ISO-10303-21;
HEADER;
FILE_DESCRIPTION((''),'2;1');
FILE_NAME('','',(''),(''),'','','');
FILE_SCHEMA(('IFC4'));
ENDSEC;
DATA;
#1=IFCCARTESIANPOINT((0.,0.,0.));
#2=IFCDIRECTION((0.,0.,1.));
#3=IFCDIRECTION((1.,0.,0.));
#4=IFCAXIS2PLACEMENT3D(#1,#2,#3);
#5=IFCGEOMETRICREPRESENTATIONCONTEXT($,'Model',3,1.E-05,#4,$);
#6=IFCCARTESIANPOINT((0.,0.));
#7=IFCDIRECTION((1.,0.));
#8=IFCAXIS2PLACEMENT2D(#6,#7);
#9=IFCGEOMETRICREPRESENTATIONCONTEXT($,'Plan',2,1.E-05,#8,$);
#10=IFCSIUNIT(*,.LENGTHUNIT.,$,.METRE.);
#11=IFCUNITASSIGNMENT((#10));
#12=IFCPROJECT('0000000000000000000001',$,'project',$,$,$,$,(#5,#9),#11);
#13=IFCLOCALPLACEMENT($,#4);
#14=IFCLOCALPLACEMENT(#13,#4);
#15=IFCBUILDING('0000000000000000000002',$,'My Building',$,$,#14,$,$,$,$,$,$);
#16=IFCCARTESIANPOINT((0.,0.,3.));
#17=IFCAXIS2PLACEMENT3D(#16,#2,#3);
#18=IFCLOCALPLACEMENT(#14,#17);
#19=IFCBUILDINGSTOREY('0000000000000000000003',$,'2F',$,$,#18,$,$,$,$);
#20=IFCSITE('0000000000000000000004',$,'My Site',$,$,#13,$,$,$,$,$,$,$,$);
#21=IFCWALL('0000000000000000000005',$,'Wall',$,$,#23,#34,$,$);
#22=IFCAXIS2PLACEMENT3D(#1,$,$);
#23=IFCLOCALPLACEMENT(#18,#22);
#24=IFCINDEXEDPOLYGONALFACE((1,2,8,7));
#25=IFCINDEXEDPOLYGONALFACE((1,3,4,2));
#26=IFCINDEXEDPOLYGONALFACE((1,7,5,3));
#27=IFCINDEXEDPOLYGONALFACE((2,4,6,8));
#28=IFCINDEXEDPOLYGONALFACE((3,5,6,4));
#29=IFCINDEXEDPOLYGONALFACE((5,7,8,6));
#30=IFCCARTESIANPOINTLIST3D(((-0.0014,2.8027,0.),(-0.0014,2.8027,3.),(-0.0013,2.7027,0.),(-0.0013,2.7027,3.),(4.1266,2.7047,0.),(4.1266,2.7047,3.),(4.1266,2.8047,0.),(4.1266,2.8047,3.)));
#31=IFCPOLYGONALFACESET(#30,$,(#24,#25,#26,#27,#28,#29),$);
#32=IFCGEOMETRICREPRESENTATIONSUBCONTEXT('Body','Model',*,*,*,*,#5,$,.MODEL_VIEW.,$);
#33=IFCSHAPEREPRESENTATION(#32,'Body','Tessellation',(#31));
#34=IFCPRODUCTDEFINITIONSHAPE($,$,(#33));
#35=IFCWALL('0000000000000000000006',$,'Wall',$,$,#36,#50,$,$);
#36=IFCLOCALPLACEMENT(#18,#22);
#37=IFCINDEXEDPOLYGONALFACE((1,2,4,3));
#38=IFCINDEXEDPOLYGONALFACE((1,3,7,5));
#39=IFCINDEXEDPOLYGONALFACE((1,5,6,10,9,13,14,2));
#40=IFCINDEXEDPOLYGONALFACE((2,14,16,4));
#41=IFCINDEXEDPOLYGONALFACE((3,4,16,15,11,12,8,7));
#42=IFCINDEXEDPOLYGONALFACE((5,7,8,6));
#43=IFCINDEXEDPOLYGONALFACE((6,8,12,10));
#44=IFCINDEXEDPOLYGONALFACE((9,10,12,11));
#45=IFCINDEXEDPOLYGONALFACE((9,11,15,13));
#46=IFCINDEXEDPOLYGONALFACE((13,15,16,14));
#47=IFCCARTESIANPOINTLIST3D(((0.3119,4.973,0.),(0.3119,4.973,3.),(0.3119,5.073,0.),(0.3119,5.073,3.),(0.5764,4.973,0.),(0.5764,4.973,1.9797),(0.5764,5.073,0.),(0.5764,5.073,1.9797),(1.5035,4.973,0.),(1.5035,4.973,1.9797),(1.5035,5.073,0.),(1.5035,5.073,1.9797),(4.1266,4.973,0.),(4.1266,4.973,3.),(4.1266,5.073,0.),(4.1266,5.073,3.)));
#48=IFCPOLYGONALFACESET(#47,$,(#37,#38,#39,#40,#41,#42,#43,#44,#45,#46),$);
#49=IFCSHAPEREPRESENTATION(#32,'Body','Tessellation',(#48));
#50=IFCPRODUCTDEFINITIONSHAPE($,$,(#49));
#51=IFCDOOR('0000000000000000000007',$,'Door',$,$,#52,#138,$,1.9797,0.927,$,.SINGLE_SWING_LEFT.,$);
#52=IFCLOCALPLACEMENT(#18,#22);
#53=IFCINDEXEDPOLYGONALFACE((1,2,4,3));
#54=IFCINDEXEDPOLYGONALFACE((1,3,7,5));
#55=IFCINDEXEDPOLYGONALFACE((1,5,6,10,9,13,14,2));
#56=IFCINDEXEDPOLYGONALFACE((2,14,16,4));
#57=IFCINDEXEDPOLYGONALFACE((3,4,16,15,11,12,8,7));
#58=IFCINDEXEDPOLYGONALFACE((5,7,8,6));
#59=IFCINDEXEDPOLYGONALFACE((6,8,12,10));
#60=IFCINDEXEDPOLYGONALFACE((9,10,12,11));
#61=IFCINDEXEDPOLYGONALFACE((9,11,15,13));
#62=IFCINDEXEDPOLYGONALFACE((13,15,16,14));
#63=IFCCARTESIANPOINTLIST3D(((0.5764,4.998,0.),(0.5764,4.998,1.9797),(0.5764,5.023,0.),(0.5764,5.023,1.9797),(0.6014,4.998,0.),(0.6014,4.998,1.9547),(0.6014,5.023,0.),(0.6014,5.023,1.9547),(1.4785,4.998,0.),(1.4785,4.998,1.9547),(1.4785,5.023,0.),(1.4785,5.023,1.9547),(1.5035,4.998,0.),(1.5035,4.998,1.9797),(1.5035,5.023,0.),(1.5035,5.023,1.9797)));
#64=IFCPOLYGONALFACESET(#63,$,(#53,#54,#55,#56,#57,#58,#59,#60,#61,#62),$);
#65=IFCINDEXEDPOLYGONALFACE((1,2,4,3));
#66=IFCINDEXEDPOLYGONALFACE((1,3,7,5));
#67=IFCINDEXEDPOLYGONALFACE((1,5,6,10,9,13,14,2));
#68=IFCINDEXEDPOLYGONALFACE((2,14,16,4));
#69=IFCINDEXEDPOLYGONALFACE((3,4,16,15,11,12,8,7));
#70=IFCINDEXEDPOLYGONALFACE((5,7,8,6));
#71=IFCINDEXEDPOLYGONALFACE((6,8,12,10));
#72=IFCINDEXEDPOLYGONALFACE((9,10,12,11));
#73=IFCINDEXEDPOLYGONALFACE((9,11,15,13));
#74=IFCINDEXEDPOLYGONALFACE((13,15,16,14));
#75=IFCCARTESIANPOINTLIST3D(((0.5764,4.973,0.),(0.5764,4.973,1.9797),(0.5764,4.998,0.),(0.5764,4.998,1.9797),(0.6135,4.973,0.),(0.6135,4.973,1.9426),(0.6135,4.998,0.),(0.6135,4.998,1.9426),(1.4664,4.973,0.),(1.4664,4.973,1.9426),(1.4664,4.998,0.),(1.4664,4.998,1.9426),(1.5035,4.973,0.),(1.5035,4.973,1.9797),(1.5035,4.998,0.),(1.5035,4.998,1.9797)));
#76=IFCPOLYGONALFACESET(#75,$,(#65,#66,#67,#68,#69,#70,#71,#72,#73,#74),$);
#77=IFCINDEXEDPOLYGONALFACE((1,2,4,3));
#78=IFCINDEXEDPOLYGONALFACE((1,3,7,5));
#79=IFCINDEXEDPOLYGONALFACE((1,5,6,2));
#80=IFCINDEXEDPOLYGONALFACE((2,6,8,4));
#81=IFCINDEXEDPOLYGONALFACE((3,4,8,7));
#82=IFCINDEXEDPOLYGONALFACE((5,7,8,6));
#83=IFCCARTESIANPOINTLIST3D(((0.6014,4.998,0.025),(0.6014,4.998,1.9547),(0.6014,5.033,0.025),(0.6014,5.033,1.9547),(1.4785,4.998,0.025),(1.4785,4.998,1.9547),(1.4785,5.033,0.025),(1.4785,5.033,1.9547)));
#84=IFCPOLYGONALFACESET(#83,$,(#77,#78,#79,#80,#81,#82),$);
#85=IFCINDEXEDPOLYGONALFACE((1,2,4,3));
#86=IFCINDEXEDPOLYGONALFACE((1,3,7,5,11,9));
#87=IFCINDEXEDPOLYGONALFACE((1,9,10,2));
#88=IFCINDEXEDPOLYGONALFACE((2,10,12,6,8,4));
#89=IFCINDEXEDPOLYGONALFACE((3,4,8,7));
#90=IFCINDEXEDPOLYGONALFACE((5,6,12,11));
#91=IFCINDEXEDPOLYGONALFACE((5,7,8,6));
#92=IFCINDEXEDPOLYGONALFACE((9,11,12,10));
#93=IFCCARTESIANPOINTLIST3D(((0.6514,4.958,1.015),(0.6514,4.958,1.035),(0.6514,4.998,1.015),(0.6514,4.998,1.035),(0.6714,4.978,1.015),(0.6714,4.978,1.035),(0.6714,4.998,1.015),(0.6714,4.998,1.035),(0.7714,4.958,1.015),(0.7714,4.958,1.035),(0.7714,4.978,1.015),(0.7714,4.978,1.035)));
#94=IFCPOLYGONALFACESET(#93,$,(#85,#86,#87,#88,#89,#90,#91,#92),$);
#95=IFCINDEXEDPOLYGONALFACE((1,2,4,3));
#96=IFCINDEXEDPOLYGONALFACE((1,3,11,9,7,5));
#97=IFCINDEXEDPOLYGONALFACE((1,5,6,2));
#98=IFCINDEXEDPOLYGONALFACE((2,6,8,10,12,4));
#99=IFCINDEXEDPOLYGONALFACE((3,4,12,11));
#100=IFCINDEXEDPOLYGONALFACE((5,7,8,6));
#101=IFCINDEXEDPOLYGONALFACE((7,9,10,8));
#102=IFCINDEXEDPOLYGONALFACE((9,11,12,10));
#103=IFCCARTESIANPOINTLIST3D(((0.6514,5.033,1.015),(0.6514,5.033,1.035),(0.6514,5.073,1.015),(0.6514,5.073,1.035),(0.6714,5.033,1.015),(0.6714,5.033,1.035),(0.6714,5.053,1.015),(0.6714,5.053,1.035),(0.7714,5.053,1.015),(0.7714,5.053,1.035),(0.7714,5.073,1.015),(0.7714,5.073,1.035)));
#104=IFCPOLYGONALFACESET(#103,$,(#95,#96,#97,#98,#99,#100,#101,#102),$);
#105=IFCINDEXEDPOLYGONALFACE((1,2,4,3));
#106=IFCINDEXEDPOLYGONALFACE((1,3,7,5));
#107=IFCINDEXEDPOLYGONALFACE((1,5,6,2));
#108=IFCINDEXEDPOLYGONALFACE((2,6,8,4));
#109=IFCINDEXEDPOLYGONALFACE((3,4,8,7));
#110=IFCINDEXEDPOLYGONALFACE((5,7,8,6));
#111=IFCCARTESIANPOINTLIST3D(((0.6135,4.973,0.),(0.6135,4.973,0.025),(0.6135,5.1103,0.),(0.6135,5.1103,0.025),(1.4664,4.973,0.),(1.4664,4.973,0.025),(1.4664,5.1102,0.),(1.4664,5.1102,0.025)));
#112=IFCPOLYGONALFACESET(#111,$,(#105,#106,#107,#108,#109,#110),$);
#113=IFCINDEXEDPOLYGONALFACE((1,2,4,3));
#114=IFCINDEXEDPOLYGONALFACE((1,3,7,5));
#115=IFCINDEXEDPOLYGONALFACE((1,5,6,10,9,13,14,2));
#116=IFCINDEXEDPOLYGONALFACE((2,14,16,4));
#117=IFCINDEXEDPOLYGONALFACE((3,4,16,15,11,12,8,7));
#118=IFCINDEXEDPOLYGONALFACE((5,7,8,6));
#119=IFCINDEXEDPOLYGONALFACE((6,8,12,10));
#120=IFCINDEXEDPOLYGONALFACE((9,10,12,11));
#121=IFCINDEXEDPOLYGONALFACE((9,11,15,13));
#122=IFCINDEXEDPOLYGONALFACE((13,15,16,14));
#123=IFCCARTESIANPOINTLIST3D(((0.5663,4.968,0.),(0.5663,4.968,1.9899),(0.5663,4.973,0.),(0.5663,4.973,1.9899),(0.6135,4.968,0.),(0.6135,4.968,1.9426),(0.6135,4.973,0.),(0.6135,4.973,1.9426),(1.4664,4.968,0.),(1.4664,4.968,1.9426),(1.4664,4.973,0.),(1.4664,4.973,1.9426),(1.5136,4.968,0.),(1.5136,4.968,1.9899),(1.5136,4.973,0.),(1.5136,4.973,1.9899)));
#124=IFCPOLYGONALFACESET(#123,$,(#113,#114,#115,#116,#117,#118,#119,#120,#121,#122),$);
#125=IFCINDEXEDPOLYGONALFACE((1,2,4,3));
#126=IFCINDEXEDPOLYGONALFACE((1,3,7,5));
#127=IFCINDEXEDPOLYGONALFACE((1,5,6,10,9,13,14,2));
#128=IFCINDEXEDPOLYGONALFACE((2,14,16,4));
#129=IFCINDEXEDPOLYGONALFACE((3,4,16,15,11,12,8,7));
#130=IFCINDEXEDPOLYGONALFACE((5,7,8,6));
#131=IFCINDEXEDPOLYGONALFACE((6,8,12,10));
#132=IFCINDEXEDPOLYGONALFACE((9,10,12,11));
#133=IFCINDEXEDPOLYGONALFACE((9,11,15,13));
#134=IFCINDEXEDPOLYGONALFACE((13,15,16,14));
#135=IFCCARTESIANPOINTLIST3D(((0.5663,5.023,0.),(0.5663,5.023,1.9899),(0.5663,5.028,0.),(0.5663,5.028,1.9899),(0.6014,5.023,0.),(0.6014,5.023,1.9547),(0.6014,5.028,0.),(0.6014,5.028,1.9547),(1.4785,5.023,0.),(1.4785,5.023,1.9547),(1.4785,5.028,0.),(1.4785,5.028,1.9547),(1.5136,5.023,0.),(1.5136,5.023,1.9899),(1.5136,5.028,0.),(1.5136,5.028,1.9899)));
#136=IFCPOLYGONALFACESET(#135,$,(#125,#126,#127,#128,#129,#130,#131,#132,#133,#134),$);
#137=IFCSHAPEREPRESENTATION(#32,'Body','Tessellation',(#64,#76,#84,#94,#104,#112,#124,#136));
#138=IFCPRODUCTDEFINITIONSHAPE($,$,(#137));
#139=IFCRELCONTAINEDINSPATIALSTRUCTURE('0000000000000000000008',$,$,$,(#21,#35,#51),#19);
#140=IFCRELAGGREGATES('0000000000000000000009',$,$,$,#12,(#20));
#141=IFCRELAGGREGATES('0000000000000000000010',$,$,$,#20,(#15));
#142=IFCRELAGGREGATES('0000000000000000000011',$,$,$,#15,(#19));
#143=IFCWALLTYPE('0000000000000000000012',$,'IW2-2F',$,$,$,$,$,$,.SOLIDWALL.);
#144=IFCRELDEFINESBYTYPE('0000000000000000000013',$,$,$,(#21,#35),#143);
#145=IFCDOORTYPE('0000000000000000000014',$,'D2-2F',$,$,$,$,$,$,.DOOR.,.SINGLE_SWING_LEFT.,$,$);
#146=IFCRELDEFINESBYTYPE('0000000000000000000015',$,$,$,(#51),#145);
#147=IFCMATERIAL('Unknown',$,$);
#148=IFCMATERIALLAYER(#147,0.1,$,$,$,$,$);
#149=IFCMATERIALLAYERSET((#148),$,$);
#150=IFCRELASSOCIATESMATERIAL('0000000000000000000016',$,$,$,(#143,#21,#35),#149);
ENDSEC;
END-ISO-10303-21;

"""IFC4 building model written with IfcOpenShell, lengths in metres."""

from ifc_helpers import new_model, entity, si_unit, frame, origin_with_axes, origin_2d_with_axis, place, context, subcontext, project, spatial, line, indexed_curve, outline, extrude, shape, source, transform, mapped, material, layer, layer_set, layer_usage, type_object, type_shapes, element, fill, save


model = new_model("IFC4")

# Units and contexts
model_context = context("Model", 3, precision=1e-05, world=origin_with_axes())
plan_context = context("Plan", 2, precision=1e-05, world=origin_2d_with_axis())
body_context_1 = subcontext(model_context, "Body", "Model", "MODEL_VIEW")
body_context_2 = subcontext(plan_context, "Body", "Plan", "PLAN_VIEW")
ifc_project = project(units=[si_unit("LENGTHUNIT", "METRE")], contexts=[model_context, plan_context])

# Site, building, storey
site_placement = place(None, origin_with_axes())
site = spatial("IfcSite", under=ifc_project, at=site_placement, Name="My Site")
building_placement = place(site_placement, origin_with_axes())
building = spatial("IfcBuilding", under=site, at=building_placement, Name="My Building")
storey_placement = place(building_placement, frame((0.0, 0.0, 3.0), z_axis=(0.0, 0.0, 1.0), x_axis=(1.0, 0.0, 0.0)))
storey = spatial("IfcBuildingStorey", under=building, at=storey_placement, Name="2F")

# Shared definitions
ifc_material = material(Name="Unknown")

# Wall
ifc_layer_1 = layer(ifc_material, 0.1)
ifc_layer_set_1 = layer_set([ifc_layer_1])
ifc_layer_usage_1 = layer_usage(ifc_layer_set_1, "AXIS2", "POSITIVE", 0.0)
wall_type_1 = type_object("IfcWallType", Name="IW2-2F", PredefinedType="SOLIDWALL", material=ifc_layer_set_1)
wall_1_placement = place(storey_placement, frame((-0.0013, 2.7027, 0.0), z_axis=(0.0, 0.0, 1.0), x_axis=(1.0, 0.000495, 0.0)))
element("IfcWall", 1, at=wall_1_placement, inside=storey, type_object=wall_type_1, material=ifc_layer_usage_1, Name="Wall", context=body_context_1, shape_type="SweptSolid", body=[
    extrude(outline(indexed_curve([(0.0, 0.0), (0.0, 0.1), (4.1279, 0.1), (4.1279, 0.0)], segments=[line(1, 2, 3, 4, 1)])), origin_with_axes(), (0.0, 0.0, 1.0), 3.0),
])

# Wall, opening, door
ifc_layer_usage_2 = layer_usage(ifc_layer_set_1, "AXIS2", "POSITIVE", 0.0)
wall_2_placement = place(storey_placement, frame((0.3119, 4.973, 0.0), z_axis=(0.0, 0.0, 1.0), x_axis=(1.0, -0.00002, 0.0)))
wall_2 = element("IfcWall", 2, at=wall_2_placement, inside=storey, type_object=wall_type_1, material=ifc_layer_usage_2, Name="Wall", context=body_context_1, shape_type="SweptSolid", body=[
    extrude(outline(indexed_curve([(0.0, 0.0), (0.0, 0.1), (3.8147, 0.1), (3.8147, 0.0)], segments=[line(1, 2, 3, 4, 1)])), origin_with_axes(), (0.0, 0.0, 1.0), 3.0),
])
shared_shape_1 = source(origin_with_axes(), body_context_1, "Body", "SweptSolid", [
    extrude(outline(indexed_curve([(0.0, 0.0), (0.927, 0.0), (0.927, 1.9797), (0.0, 1.9797)], segments=[line(1, 2, 3, 4, 1)])), frame((0.0, -0.6, 0.0), z_axis=(0.0, -1.0, 0.0), x_axis=(1.0, 0.0, 0.0)), (0.0, 0.0, -1.0), 1.2),
])
opening_1_placement = place(wall_2_placement, frame((0.2645, 0.0, 0.0), z_axis=(0.0, 0.0, 1.0), x_axis=(1.0, 0.0, 0.0)))
opening_1 = element("IfcOpeningElement", 3, at=opening_1_placement, cuts=wall_2, PredefinedType="OPENING", context=body_context_1, shape_type="MappedRepresentation", body=[
    mapped(shared_shape_1, transform((0.0, 0.0, 0.0), x_axis=(1.0, 0.0, 0.0), y_axis=(0.0, 1.0, 0.0), z_axis=(0.0, 0.0, 1.0), scale=1.0)),
])
door_type = type_object("IfcDoorType", Name="D2-2F", OperationType="SINGLE_SWING_LEFT", PredefinedType="DOOR")
shared_shape_2 = source(origin_with_axes(), body_context_1, "Body", "SweptSolid", [
    extrude(outline(indexed_curve([(0.0, 0.0), (0.0, 1.9797), (0.927, 1.9797), (0.927, 0.0), (0.902, 0.0), (0.902, 1.9547), (0.025, 1.9547), (0.025, 0.0)], segments=[line(1, 2, 3, 4, 5, 6, 7, 8, 1)])), frame((0.0, 0.025, 0.0), z_axis=(0.0, -1.0, 0.0), x_axis=(1.0, 0.0, 0.0)), (0.0, 0.0, -1.0), 0.025),
    extrude(outline(indexed_curve([(0.0, 0.0), (0.0, 1.9797), (0.927, 1.9797), (0.927, 0.0), (0.8899, 0.0), (0.8899, 1.9426), (0.0371, 1.9426), (0.0371, 0.0)], segments=[line(1, 2, 3, 4, 5, 6, 7, 8, 1)])), frame((0.0, 0.0, 0.0), z_axis=(0.0, -1.0, 0.0), x_axis=(1.0, 0.0, 0.0)), (0.0, 0.0, -1.0), 0.025),
    extrude(outline(indexed_curve([(0.0, 0.0), (0.877, 0.0), (0.877, 0.035), (0.0, 0.035)], segments=[line(1, 2, 3, 4, 1)])), frame((0.025, 0.025, 0.025), z_axis=(0.0, 0.0, 1.0), x_axis=(1.0, 0.0, 0.0)), (0.0, 0.0, 1.0), 1.9297),
    extrude(outline(indexed_curve([(0.0, 0.0), (0.0, -0.04), (0.12, -0.04), (0.12, -0.02), (0.02, -0.02), (0.02, 0.0)], segments=[line(1, 2, 3, 4, 5, 6, 1)])), frame((0.075, 0.025, 1.015), z_axis=(0.0, 0.0, 1.0), x_axis=(1.0, 0.0, 0.0)), (0.0, 0.0, 1.0), 0.02),
    extrude(outline(indexed_curve([(0.0, 0.0), (0.0, 0.04), (0.12, 0.04), (0.12, 0.02), (0.02, 0.02), (0.02, 0.0)], segments=[line(1, 2, 3, 4, 5, 6, 1)])), frame((0.075, 0.06, 1.015), z_axis=(0.0, 0.0, 1.0), x_axis=(1.0, 0.0, 0.0)), (0.0, 0.0, 1.0), 0.02),
    extrude(outline(indexed_curve([(0.0, 0.0), (0.8529, 0.0), (0.8529, 0.1372), (0.0, 0.1372)], segments=[line(1, 2, 3, 4, 1)])), frame((0.0371, 0.0, 0.0), z_axis=(0.0, 0.0, 1.0), x_axis=(1.0, 0.0, 0.0)), (0.0, 0.0, 1.0), 0.025),
    extrude(outline(indexed_curve([(0.0, 0.0), (0.0, 1.9899), (0.9474, 1.9899), (0.9474, 0.0), (0.9001, 0.0), (0.9001, 1.9426), (0.0473, 1.9426), (0.0473, 0.0)], segments=[line(1, 2, 3, 4, 5, 6, 7, 8, 1)])), frame((-0.0102, -0.005, 0.0), z_axis=(0.0, -1.0, 0.0), x_axis=(1.0, 0.0, 0.0)), (0.0, 0.0, -1.0), 0.005),
    extrude(outline(indexed_curve([(0.0, 0.0), (0.0, 1.9899), (0.9474, 1.9899), (0.9474, 0.0), (0.9122, 0.0), (0.9122, 1.9547), (0.0352, 1.9547), (0.0352, 0.0)], segments=[line(1, 2, 3, 4, 5, 6, 7, 8, 1)])), frame((-0.0102, 0.05, 0.0), z_axis=(0.0, -1.0, 0.0), x_axis=(1.0, 0.0, 0.0)), (0.0, 0.0, -1.0), 0.005),
])
shared_shape_3 = source(origin_with_axes(), body_context_2, "Body", "Curve2D", [
    entity("IfcIndexedPolyCurve", entity("IfcCartesianPointList2D", [[0.0, 0.0], [0.0, 0.05], [0.025, 0.05], [0.025, 0.025], [0.0371, 0.025], [0.0371, 0.0]]), [entity("IfcLineIndex", [1, 2, 3, 4, 5, 6, 1])]),
    entity("IfcIndexedPolyCurve", entity("IfcCartesianPointList2D", [[0.927, 0.0], [0.927, 0.05], [0.902, 0.05], [0.902, 0.025], [0.8899, 0.025], [0.8899, 0.0]]), [entity("IfcLineIndex", [1, 2, 3, 4, 5, 6, 1])]),
    entity("IfcTrimmedCurve", entity("IfcEllipse", entity("IfcAxis2Placement2D", entity("IfcCartesianPoint", [0.867, 0.05]), entity("IfcDirection", [1.0, 0.0])), 0.842, 0.877), [entity("IfcCartesianPoint", [0.867, 0.927])], [entity("IfcCartesianPoint", [0.025, 0.05])], True, "CARTESIAN"),
    entity("IfcIndexedPolyCurve", entity("IfcCartesianPointList2D", [[0.902, 0.05], [0.867, 0.05], [0.867, 0.927], [0.902, 0.927]]), [entity("IfcLineIndex", [1, 2, 3, 4, 1])]),
])
type_shapes(door_type, [shared_shape_2, shared_shape_3])
door_placement = place(opening_1_placement, frame((0.0, 0.0, 0.0), z_axis=(0.0, 0.0, 1.0), x_axis=(1.0, 0.0, 0.0)))
door = element("IfcDoor", 4, at=door_placement, inside=storey, type_object=door_type, Name="Door", OperationType="SINGLE_SWING_LEFT", OverallHeight=1.9797, OverallWidth=0.927, shapes=[
    shape(body_context_1, "Body", "MappedRepresentation", [mapped(shared_shape_2, transform((0.0, 0.0, 0.0), x_axis=(1.0, 0.0, 0.0), y_axis=(0.0, 1.0, 0.0), z_axis=(0.0, 0.0, 1.0), scale=1.0))]),
    shape(body_context_2, "Body", "MappedRepresentation", [mapped(shared_shape_3, transform((0.0, 0.0, 0.0), x_axis=(1.0, 0.0, 0.0), y_axis=(0.0, 1.0, 0.0), z_axis=(0.0, 0.0, 1.0), scale=1.0))]),
])
fill(opening_1, door)

save(model, "model.ifc")
